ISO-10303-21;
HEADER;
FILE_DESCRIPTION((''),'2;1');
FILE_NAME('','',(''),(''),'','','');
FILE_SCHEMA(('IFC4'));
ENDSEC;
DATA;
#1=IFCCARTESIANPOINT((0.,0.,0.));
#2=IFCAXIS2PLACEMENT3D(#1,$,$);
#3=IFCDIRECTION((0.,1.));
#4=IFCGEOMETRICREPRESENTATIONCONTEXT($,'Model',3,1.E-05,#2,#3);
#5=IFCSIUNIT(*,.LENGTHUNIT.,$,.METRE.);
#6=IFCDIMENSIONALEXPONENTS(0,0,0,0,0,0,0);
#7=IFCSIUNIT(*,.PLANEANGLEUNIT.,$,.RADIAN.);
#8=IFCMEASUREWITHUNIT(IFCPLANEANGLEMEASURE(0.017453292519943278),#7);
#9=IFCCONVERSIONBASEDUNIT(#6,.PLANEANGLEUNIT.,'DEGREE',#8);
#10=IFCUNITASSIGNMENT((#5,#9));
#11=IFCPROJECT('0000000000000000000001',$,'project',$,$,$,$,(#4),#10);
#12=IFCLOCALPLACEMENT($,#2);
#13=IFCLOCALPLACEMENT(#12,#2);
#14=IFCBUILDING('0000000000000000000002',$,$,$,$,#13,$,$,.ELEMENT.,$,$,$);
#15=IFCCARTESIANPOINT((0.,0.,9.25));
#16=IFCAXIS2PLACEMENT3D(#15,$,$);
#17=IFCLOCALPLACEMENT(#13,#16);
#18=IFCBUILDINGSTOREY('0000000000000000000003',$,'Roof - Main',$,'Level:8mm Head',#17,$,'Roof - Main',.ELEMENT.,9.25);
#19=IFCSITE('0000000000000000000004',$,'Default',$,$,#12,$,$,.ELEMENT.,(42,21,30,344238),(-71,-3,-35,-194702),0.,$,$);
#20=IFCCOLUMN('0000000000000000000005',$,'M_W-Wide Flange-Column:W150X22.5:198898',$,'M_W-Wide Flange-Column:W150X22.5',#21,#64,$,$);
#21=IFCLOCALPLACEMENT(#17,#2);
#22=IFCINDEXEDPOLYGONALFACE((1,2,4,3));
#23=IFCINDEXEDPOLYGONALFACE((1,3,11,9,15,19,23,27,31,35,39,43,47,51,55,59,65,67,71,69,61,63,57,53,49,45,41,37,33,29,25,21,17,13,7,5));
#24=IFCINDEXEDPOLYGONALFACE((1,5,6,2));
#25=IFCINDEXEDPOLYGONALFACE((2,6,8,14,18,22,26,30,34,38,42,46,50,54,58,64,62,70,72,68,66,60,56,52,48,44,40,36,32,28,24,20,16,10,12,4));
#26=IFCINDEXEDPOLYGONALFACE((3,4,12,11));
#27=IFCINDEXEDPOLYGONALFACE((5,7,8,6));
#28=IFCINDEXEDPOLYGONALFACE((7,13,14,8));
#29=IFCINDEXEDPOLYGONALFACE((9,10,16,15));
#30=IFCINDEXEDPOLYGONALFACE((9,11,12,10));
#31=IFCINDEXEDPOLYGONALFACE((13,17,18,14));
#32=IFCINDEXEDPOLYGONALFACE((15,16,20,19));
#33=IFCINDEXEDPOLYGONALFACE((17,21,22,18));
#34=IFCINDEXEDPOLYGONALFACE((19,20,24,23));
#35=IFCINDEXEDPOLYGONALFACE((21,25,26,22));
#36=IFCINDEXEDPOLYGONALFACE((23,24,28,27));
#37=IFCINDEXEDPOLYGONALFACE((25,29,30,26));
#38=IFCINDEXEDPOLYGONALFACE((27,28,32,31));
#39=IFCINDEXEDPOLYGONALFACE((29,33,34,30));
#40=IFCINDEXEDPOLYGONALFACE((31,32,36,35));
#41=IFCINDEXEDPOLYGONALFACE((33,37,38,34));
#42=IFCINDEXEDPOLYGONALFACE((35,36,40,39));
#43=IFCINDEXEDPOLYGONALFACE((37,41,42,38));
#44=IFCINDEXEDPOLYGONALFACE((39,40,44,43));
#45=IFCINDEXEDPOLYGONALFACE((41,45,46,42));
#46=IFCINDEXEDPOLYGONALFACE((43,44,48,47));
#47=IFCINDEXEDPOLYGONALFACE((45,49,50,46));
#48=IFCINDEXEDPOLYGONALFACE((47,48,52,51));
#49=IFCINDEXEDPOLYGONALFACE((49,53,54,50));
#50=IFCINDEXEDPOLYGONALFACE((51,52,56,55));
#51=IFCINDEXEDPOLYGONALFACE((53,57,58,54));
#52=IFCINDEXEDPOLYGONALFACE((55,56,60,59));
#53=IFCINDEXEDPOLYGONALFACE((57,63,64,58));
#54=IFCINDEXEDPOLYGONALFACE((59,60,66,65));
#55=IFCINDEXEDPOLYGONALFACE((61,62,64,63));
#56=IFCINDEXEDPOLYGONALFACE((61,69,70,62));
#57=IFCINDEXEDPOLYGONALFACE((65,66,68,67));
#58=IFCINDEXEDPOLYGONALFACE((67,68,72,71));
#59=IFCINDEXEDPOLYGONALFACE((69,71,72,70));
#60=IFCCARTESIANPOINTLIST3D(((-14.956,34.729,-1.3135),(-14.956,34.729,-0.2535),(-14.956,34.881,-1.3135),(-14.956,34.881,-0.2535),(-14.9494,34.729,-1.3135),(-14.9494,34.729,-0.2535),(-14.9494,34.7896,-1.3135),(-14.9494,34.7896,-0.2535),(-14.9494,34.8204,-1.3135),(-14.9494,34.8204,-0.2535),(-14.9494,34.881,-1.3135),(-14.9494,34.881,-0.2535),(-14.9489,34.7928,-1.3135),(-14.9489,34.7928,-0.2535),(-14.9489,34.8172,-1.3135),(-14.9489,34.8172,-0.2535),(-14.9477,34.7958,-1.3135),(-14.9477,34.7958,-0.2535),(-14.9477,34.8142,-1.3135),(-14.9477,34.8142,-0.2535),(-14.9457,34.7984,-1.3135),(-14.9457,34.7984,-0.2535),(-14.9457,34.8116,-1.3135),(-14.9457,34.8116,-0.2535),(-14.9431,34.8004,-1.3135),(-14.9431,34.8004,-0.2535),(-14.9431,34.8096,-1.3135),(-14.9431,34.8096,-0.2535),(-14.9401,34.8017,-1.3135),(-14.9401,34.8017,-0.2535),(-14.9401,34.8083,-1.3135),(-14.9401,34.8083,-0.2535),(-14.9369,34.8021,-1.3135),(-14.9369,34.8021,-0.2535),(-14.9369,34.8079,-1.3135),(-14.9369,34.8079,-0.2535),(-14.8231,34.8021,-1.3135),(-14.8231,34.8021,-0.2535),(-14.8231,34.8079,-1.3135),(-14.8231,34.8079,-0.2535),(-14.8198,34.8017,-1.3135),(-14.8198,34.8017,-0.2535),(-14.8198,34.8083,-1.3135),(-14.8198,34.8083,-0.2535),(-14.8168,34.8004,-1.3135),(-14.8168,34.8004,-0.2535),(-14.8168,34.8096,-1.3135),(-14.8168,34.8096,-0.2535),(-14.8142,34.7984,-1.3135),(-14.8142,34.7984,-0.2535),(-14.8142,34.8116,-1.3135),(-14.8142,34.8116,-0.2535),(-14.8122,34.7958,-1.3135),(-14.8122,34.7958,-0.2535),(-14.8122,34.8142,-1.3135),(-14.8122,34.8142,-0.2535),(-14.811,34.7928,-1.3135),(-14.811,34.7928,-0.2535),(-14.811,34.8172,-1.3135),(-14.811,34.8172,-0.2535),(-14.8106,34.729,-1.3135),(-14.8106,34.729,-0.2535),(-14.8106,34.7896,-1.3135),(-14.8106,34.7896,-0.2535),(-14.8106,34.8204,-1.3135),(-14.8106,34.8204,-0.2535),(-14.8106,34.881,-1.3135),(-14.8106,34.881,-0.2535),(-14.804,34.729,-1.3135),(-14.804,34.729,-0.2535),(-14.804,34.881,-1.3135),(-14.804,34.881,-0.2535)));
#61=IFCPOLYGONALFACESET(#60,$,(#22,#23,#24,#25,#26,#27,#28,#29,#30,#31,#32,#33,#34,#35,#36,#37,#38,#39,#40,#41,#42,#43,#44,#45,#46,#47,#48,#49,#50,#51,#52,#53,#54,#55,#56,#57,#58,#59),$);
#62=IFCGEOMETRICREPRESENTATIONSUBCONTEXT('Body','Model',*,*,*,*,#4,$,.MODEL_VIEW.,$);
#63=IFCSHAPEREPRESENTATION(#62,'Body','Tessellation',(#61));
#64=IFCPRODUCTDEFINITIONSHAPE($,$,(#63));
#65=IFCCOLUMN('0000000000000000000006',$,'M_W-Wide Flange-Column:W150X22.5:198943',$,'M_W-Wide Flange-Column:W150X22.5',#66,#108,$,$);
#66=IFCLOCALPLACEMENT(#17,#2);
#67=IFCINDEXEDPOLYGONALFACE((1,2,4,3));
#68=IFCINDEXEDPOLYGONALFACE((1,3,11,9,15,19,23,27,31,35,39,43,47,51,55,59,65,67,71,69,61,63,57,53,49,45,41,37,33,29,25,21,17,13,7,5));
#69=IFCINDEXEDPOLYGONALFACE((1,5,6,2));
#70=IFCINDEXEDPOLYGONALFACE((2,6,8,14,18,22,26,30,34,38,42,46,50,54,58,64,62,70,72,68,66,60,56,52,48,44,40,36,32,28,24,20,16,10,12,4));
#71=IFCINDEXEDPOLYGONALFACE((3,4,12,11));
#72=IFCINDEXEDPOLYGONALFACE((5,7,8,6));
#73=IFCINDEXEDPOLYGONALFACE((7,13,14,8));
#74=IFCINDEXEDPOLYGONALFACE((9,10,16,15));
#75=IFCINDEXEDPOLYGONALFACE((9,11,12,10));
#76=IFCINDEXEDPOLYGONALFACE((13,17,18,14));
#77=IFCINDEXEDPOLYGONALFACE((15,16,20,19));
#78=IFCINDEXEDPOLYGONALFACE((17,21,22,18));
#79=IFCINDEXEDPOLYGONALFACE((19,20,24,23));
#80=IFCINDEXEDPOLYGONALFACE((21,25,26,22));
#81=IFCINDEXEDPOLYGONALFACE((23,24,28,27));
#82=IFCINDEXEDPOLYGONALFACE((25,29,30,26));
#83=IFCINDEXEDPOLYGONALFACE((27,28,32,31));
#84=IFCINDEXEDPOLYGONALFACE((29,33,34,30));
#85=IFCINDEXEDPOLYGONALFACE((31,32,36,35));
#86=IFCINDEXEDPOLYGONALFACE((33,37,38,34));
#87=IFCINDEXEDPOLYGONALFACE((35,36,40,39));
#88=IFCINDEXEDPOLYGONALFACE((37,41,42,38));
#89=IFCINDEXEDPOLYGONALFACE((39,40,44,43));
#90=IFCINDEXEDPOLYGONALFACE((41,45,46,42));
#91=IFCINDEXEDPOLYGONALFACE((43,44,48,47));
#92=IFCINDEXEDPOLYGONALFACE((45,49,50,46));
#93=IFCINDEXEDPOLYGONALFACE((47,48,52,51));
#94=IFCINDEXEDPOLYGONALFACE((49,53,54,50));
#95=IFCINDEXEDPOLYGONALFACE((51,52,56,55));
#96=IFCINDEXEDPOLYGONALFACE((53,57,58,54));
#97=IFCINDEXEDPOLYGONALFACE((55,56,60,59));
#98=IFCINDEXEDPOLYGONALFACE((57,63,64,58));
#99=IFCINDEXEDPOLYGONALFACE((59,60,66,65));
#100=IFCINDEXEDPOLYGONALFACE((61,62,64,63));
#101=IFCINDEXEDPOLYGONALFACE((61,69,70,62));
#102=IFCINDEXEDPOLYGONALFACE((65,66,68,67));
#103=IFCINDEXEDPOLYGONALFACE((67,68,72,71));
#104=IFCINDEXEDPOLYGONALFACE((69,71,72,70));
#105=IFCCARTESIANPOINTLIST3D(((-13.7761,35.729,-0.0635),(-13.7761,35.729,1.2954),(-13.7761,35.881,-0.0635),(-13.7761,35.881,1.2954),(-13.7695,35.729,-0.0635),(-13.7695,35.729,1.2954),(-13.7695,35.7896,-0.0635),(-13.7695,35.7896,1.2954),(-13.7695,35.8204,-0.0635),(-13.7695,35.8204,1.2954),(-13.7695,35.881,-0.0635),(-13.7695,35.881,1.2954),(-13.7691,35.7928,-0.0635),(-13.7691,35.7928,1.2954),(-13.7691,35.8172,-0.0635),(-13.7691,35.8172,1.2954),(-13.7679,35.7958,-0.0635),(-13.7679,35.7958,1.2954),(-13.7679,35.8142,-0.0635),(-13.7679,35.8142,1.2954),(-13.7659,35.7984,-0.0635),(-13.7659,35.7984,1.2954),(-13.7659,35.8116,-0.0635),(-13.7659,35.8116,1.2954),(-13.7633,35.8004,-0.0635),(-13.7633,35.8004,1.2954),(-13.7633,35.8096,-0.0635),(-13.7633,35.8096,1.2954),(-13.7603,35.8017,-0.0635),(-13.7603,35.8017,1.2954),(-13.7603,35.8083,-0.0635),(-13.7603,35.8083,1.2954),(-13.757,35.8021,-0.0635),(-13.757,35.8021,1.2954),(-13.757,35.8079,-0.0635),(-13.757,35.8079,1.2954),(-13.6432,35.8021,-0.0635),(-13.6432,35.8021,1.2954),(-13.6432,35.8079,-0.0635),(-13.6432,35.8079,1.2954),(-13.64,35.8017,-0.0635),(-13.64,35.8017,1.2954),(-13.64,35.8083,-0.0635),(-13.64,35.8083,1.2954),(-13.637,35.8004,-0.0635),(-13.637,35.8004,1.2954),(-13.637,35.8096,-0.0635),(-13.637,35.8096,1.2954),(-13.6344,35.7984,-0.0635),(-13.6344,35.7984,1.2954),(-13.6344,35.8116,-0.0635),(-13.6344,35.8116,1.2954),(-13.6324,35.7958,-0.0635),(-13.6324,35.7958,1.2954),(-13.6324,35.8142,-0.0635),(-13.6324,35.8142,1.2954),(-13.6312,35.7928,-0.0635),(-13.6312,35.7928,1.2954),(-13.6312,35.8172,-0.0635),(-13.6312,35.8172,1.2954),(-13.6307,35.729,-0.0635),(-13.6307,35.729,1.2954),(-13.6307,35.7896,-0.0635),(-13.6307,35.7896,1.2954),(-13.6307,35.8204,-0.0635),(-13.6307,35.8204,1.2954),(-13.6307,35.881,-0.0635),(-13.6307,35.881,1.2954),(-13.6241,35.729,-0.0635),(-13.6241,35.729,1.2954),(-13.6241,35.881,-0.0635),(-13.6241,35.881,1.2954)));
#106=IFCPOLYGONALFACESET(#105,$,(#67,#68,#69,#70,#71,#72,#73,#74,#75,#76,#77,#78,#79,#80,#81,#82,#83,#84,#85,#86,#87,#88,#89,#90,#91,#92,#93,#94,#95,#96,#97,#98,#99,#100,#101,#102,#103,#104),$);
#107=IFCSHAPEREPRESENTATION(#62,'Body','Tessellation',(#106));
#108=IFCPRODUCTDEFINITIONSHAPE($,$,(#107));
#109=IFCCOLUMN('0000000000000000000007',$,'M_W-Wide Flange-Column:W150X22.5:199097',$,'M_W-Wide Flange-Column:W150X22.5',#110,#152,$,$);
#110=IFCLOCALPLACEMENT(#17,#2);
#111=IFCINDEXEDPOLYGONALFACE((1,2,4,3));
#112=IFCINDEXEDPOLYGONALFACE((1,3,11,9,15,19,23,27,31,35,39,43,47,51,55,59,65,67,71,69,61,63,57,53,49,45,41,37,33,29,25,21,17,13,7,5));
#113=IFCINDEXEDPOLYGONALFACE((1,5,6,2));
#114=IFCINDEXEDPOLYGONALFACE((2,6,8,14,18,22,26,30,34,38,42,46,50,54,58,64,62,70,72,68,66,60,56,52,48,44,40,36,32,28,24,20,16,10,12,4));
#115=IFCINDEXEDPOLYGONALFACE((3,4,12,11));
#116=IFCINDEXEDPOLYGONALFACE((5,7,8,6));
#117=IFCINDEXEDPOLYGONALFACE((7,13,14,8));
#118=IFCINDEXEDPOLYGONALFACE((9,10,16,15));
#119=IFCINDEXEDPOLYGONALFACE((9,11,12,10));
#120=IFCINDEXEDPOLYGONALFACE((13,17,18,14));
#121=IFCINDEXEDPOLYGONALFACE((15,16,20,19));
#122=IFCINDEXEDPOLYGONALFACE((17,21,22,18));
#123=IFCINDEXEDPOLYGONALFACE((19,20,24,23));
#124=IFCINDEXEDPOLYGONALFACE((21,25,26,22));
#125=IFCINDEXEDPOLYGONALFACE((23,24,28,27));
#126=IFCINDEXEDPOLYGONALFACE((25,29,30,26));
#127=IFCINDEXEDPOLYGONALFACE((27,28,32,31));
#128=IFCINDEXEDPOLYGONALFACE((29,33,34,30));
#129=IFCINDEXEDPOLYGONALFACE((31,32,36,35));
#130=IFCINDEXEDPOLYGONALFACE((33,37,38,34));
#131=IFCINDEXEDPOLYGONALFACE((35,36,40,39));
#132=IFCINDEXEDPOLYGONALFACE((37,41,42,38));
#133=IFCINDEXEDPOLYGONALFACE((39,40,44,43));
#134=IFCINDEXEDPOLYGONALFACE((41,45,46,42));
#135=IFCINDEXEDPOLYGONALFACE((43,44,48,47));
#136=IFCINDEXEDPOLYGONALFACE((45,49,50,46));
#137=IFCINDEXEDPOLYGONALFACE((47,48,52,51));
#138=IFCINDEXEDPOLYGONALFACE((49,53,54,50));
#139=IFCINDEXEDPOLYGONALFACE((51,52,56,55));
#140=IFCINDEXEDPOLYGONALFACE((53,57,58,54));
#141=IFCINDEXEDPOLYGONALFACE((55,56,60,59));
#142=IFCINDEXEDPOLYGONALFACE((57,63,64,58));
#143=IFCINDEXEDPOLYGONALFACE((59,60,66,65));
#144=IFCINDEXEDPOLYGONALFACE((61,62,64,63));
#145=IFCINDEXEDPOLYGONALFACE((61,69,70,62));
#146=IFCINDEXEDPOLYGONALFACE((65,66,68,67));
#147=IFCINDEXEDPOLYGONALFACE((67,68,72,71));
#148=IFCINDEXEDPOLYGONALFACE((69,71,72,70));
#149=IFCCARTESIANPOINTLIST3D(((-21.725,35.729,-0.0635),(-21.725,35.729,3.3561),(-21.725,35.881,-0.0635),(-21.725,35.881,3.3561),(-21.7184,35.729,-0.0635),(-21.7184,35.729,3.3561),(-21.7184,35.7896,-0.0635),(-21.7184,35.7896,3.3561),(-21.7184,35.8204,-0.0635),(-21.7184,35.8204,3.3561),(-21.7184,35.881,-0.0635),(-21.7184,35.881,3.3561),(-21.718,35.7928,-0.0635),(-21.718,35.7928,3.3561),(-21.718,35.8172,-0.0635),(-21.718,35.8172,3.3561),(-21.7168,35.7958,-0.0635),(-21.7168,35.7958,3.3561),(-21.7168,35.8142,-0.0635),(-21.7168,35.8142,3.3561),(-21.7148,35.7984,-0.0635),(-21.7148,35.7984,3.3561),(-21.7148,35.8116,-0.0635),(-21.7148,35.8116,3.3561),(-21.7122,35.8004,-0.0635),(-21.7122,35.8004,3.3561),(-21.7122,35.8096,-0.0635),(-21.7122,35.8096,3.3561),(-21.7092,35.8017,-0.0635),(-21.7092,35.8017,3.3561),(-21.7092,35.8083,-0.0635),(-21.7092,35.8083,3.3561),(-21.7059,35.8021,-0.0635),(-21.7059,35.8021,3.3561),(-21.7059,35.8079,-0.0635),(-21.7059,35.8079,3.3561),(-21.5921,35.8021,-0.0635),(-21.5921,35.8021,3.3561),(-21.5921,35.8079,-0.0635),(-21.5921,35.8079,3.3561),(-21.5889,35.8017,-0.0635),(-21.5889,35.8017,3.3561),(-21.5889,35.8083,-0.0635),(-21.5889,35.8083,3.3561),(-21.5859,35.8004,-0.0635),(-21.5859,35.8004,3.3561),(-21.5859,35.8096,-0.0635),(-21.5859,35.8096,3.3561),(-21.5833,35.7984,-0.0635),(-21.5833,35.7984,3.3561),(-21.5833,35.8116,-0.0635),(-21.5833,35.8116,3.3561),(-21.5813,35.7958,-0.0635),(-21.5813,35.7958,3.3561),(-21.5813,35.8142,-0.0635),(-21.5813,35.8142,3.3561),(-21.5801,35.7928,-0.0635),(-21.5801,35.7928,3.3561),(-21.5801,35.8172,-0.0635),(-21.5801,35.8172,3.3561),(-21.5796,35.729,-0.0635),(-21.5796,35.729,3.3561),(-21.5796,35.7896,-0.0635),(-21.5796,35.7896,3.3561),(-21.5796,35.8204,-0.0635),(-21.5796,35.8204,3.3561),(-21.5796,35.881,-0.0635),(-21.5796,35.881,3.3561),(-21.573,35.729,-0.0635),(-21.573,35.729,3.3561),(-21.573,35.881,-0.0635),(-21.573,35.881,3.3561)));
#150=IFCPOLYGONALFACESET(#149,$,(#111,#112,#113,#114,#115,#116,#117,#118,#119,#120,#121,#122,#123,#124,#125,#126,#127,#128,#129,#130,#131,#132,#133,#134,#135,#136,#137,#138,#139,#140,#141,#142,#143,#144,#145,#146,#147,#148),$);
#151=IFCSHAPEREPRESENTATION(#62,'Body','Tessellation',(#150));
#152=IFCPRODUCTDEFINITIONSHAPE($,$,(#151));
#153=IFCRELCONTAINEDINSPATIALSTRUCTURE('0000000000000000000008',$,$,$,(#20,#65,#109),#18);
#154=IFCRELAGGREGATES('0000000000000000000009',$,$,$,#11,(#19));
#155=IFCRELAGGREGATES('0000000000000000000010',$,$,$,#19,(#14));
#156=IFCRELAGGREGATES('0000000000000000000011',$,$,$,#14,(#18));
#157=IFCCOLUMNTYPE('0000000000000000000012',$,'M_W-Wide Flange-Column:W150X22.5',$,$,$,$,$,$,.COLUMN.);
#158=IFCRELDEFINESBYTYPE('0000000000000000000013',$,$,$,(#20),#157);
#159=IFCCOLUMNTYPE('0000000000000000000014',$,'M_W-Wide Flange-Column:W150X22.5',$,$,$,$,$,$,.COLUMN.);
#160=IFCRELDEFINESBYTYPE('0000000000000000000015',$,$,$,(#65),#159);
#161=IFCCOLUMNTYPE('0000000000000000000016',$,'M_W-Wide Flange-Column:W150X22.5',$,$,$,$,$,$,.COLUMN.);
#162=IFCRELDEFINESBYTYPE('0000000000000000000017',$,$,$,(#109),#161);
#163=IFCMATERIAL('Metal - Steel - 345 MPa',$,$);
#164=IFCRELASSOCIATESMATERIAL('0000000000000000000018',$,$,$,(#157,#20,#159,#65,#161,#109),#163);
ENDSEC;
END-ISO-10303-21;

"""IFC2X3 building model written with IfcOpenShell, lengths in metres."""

from ifc_helpers import new_model, entity, si_unit, converted_unit, direction, frame, frame_2d, origin, place, context, subcontext, project, spatial, i_section, extrude, source, transform, mapped, material, type_object, type_shapes, element, save


model = new_model("IFC2X3")

# Units and contexts
model_context = context("Model", 3, precision=1e-05, world=origin(), true_north=direction((0.0, 1.0)))
body_context = subcontext(model_context, "Body", "Model", "MODEL_VIEW")
ifc_project = project(units=[si_unit("LENGTHUNIT", "METRE"), converted_unit("PLANEANGLEUNIT", "DEGREE", entity("IfcPlaneAngleMeasure", 0.017453292519943278), si_unit("PLANEANGLEUNIT", "RADIAN"), dimensions=[0, 0, 0, 0, 0, 0, 0])], contexts=[model_context])

# Site, building, storey
site_placement = place(None, origin())
site = spatial("IfcSite", under=ifc_project, at=site_placement, Name="Default", CompositionType="ELEMENT", RefLatitude=(42, 21, 30, 344238), RefLongitude=(-71, -3, -35, -194702), RefElevation=0.0)
building_placement = place(site_placement, origin())
building = spatial("IfcBuilding", under=site, at=building_placement, CompositionType="ELEMENT")
storey_placement = place(building_placement, frame((0.0, 0.0, 9.25)))
storey = spatial("IfcBuildingStorey", under=building, at=storey_placement, Name="Roof - Main", ObjectType="Level:8mm Head", LongName="Roof - Main", CompositionType="ELEMENT", Elevation=9.25)

# Columns
ifc_material_1 = material(Name="Metal - Steel - 345 MPa")
column_type_1 = type_object("IfcColumnType", Name="M_W-Wide Flange-Column:W150X22.5", PredefinedType="COLUMN", material=ifc_material_1)
shared_shape_1 = source(origin(), body_context, "Body", "SweptSolid", [
    extrude(i_section(OverallWidth=0.152, OverallDepth=0.152, WebThickness=0.0058, FlangeThickness=0.0066, FilletRadius=0.0125, at=frame_2d((0.0, 0.0), x_axis=(1.0, 0.0))), frame((0.0, 0.0, 7.9365), z_axis=(0.0, 0.0, 1.0), x_axis=(-1.0, 0.0, 0.0)), (0.0, 0.0, 1.0), 1.06),
])
type_shapes(column_type_1, [shared_shape_1])
column_1_placement = place(storey_placement, frame((-14.88, 34.805, -9.25), z_axis=(0.0, 0.0, 1.0), x_axis=(0.0, 1.0, 0.0)))
element("IfcColumn", 1, at=column_1_placement, inside=storey, type_object=column_type_1, material=ifc_material_1, Name="M_W-Wide Flange-Column:W150X22.5:198898", ObjectType="M_W-Wide Flange-Column:W150X22.5", context=body_context, shape_type="MappedRepresentation", body=[
    mapped(shared_shape_1, transform((0.0, 0.0, 0.0), scale=1.0)),
])
column_type_2 = type_object("IfcColumnType", Name="M_W-Wide Flange-Column:W150X22.5", PredefinedType="COLUMN", material=ifc_material_1)
shared_shape_2 = source(origin(), body_context, "Body", "SweptSolid", [
    extrude(i_section(OverallWidth=0.152, OverallDepth=0.152, WebThickness=0.0058, FlangeThickness=0.0066, FilletRadius=0.0125, at=frame_2d((0.0, 0.0), x_axis=(1.0, 0.0))), frame((0.0, 0.0, 9.1865), z_axis=(0.0, 0.0, 1.0), x_axis=(-1.0, 0.0, 0.0)), (0.0, 0.0, 1.0), 1.3589),
])
type_shapes(column_type_2, [shared_shape_2])
column_2_placement = place(storey_placement, frame((-13.7001, 35.805, -9.25), z_axis=(0.0, 0.0, 1.0), x_axis=(0.0, 1.0, 0.0)))
element("IfcColumn", 2, at=column_2_placement, inside=storey, type_object=column_type_2, material=ifc_material_1, Name="M_W-Wide Flange-Column:W150X22.5:198943", ObjectType="M_W-Wide Flange-Column:W150X22.5", context=body_context, shape_type="MappedRepresentation", body=[
    mapped(shared_shape_2, transform((0.0, 0.0, 0.0), scale=1.0)),
])
column_type_3 = type_object("IfcColumnType", Name="M_W-Wide Flange-Column:W150X22.5", PredefinedType="COLUMN", material=ifc_material_1)
shared_shape_3 = source(origin(), body_context, "Body", "SweptSolid", [
    extrude(i_section(OverallWidth=0.152, OverallDepth=0.152, WebThickness=0.0058, FlangeThickness=0.0066, FilletRadius=0.0125, at=frame_2d((0.0, 0.0), x_axis=(1.0, 0.0))), frame((0.0, 0.0, 9.1865), z_axis=(0.0, 0.0, 1.0), x_axis=(-1.0, 0.0, 0.0)), (0.0, 0.0, 1.0), 3.4196),
])
type_shapes(column_type_3, [shared_shape_3])
column_3_placement = place(storey_placement, frame((-21.649, 35.805, -9.25), z_axis=(0.0, 0.0, 1.0), x_axis=(0.0, 1.0, 0.0)))
element("IfcColumn", 3, at=column_3_placement, inside=storey, type_object=column_type_3, material=ifc_material_1, Name="M_W-Wide Flange-Column:W150X22.5:199097", ObjectType="M_W-Wide Flange-Column:W150X22.5", context=body_context, shape_type="MappedRepresentation", body=[
    mapped(shared_shape_3, transform((0.0, 0.0, 0.0), scale=1.0)),
])

save(model, "model.ifc")
